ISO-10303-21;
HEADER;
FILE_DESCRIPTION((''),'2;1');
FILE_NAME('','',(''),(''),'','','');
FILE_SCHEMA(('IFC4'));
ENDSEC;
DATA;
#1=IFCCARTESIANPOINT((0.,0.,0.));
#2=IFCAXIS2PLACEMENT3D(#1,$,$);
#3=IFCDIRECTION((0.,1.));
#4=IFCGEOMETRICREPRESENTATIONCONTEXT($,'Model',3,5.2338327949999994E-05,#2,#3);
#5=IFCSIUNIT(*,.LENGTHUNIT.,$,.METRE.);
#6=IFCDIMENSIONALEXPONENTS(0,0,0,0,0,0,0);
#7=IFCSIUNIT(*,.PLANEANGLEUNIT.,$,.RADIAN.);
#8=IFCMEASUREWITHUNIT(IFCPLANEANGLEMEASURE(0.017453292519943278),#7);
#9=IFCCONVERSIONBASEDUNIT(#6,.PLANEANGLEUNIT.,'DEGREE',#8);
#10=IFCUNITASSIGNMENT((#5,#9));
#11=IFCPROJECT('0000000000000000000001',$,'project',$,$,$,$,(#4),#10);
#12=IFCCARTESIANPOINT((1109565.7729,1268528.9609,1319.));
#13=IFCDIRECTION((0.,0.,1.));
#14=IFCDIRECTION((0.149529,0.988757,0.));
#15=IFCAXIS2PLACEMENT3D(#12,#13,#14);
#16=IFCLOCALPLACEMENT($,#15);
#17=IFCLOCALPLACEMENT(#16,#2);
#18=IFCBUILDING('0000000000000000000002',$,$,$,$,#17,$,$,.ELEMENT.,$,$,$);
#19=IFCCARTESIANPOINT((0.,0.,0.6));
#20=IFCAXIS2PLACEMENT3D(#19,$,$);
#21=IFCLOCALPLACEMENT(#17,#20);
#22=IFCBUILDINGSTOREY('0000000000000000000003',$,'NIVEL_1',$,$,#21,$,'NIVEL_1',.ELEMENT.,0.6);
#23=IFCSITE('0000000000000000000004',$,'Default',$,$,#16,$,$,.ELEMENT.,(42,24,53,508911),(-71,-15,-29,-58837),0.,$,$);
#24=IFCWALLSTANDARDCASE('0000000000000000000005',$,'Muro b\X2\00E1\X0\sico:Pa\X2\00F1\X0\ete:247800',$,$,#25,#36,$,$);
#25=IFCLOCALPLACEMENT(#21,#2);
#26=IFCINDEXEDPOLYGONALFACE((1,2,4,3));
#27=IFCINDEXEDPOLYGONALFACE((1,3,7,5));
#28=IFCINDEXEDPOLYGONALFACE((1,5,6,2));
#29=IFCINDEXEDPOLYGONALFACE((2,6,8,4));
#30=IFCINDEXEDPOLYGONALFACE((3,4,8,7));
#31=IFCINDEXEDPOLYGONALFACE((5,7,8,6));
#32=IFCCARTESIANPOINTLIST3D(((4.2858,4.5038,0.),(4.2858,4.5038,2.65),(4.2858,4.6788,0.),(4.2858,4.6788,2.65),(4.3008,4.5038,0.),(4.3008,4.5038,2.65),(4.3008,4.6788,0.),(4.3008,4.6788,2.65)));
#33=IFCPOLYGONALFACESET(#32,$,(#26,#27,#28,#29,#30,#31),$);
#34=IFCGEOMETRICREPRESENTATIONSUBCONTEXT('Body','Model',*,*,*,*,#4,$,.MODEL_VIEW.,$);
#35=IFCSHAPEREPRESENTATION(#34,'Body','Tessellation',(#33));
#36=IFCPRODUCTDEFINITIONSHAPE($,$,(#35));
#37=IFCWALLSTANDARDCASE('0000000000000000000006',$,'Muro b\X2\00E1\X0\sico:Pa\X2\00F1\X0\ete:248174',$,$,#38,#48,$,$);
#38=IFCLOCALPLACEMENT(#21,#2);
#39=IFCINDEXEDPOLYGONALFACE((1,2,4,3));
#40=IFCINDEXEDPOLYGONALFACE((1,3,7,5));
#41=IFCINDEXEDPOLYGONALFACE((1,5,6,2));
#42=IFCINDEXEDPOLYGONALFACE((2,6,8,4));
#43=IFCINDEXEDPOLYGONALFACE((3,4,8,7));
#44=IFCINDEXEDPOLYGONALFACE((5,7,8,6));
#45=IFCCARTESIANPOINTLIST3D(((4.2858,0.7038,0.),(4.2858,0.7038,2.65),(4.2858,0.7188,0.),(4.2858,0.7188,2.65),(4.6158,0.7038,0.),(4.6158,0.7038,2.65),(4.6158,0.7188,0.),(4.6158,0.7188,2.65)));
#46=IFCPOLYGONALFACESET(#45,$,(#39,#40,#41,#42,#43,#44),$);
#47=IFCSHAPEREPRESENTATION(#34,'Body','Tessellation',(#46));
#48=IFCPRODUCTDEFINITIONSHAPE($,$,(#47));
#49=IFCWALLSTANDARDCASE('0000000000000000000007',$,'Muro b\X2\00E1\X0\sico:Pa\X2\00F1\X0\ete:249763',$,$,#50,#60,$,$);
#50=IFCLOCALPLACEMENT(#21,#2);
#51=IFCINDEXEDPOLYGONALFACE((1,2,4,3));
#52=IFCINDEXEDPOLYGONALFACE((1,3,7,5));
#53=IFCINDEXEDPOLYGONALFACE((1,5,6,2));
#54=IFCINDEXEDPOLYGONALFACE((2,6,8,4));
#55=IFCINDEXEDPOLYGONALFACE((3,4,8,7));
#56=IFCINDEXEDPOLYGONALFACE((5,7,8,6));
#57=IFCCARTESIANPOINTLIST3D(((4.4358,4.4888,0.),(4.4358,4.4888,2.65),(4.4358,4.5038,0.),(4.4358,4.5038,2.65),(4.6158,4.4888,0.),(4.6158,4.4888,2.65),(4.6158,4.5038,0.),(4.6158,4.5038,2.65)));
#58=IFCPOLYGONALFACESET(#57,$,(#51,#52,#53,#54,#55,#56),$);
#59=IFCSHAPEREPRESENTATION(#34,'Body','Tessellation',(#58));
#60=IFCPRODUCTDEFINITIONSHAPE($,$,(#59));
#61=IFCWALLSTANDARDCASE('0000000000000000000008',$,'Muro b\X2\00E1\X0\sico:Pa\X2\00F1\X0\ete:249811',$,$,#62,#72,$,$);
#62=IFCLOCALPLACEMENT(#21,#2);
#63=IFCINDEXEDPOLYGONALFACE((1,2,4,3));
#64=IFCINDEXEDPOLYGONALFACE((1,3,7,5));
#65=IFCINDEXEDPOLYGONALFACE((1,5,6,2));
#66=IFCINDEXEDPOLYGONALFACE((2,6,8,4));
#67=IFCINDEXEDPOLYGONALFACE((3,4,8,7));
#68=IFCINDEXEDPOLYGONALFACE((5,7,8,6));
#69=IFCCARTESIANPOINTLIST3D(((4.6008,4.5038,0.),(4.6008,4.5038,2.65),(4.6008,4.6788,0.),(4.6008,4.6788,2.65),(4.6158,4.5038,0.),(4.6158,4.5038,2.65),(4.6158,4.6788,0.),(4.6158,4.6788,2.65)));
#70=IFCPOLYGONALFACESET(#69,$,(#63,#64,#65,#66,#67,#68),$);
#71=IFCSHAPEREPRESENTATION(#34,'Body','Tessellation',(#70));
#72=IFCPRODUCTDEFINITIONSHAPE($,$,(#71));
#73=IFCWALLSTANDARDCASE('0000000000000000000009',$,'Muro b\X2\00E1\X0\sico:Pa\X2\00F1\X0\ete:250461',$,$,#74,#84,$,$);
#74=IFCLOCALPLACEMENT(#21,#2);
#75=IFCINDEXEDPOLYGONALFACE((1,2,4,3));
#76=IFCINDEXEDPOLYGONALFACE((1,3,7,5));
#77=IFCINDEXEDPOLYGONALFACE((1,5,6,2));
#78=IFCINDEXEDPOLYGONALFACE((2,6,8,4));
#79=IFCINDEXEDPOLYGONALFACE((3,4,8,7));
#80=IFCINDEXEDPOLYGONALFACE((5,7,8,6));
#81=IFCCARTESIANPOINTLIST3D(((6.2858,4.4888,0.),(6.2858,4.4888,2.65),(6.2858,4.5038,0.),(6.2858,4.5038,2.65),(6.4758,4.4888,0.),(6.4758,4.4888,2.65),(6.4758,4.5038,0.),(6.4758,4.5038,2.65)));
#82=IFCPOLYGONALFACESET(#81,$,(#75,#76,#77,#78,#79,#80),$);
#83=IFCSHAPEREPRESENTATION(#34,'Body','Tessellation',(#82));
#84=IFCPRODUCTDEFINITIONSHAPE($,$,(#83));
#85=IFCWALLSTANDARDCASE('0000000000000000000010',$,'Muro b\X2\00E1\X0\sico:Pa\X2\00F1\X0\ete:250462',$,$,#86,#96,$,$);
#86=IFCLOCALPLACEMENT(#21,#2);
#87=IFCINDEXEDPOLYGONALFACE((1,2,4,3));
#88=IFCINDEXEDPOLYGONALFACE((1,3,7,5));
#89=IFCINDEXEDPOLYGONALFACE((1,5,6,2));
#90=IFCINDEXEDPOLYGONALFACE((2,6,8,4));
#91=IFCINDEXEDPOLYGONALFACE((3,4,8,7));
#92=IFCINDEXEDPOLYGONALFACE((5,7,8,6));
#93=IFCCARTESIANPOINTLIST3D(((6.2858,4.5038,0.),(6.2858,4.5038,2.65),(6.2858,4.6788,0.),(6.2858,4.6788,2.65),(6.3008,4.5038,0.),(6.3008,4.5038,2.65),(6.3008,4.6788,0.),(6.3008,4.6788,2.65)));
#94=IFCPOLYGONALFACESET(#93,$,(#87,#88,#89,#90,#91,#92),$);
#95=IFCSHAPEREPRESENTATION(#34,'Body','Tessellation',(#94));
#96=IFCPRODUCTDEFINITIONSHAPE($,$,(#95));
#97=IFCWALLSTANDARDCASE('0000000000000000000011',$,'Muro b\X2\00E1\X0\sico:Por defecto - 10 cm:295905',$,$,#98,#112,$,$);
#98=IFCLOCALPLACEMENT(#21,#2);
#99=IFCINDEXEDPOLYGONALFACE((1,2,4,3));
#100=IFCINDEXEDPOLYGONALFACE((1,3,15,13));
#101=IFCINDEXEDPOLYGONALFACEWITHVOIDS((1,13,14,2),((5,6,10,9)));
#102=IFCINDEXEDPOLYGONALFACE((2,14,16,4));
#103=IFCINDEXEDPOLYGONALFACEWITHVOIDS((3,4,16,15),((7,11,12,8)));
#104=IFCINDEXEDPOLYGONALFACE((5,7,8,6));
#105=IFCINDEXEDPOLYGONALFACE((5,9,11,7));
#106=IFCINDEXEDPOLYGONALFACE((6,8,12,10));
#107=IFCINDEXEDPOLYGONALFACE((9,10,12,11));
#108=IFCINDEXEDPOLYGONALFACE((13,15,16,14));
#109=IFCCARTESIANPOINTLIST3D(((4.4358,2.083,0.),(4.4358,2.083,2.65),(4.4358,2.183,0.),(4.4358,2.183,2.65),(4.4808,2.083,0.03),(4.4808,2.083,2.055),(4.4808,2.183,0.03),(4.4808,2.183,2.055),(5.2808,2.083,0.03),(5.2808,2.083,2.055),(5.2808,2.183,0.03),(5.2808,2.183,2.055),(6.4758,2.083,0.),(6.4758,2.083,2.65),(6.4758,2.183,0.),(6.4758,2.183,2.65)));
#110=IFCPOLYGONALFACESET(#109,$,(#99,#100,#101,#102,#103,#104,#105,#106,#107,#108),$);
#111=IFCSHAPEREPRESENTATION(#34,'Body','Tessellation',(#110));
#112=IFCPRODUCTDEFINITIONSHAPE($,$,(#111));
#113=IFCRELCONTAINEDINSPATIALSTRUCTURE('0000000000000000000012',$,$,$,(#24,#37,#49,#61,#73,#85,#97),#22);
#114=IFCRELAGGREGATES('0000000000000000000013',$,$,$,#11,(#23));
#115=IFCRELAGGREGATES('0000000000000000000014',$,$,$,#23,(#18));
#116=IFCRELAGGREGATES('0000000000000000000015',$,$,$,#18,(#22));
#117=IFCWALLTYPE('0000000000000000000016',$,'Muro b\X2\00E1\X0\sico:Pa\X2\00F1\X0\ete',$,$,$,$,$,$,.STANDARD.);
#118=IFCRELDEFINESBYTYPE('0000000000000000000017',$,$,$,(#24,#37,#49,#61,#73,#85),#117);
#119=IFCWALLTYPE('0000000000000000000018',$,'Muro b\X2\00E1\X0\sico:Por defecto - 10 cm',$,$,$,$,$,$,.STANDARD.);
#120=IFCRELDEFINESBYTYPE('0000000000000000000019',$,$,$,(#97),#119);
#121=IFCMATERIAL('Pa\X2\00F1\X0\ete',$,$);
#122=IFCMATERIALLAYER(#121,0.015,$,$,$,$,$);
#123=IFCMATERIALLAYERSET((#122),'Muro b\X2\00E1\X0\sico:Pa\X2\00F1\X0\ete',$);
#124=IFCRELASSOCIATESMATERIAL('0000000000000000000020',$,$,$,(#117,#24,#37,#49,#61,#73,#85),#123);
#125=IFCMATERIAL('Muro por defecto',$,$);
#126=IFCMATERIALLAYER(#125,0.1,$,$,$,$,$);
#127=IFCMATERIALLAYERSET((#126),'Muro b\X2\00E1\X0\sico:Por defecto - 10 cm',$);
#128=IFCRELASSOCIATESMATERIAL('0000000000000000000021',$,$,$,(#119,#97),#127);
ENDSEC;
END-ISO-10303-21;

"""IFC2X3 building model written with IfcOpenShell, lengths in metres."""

from ifc_helpers import new_model, entity, si_unit, converted_unit, direction, frame, frame_2d, origin, place, context, subcontext, project, spatial, rectangle, extrude, material, layer, layer_set, layer_usage, type_object, element, save


model = new_model("IFC2X3")

# Units and contexts
model_context = context("Model", 3, precision=5.2338327949999994e-05, world=origin(), true_north=direction((0.0, 1.0)))
body_context = subcontext(model_context, "Body", "Model", "MODEL_VIEW")
ifc_project = project(units=[si_unit("LENGTHUNIT", "METRE"), converted_unit("PLANEANGLEUNIT", "DEGREE", entity("IfcPlaneAngleMeasure", 0.017453292519943278), si_unit("PLANEANGLEUNIT", "RADIAN"), dimensions=[0, 0, 0, 0, 0, 0, 0])], contexts=[model_context])

# Site, building, storey
site_placement = place(None, frame((1109565.7729, 1268528.9609, 1319.0), z_axis=(0.0, 0.0, 1.0), x_axis=(0.149529, 0.988757, 0.0)))
site = spatial("IfcSite", under=ifc_project, at=site_placement, Name="Default", CompositionType="ELEMENT", RefLatitude=(42, 24, 53, 508911), RefLongitude=(-71, -15, -29, -58837), RefElevation=0.0)
building_placement = place(site_placement, origin())
building = spatial("IfcBuilding", under=site, at=building_placement, CompositionType="ELEMENT")
storey_placement = place(building_placement, frame((0.0, 0.0, 0.6)))
storey = spatial("IfcBuildingStorey", under=building, at=storey_placement, Name="NIVEL_1", LongName="NIVEL_1", CompositionType="ELEMENT", Elevation=0.6)

# Shared definitions
ifc_material_1 = material(Name="Pañete")

# Walls
ifc_layer_1 = layer(ifc_material_1, 0.015)
ifc_layer_set_1 = layer_set([ifc_layer_1], Name="Muro básico:Pañete")
ifc_layer_usage_1 = layer_usage(ifc_layer_set_1, "AXIS2", "NEGATIVE", 0.0075)
wall_type_1 = type_object("IfcWallType", Name="Muro básico:Pañete", PredefinedType="STANDARD", material=ifc_layer_set_1)
wall_1_placement = place(storey_placement, frame((4.2933, 4.5038, 0.0), z_axis=(0.0, 0.0, 1.0), x_axis=(0.0, 1.0, 0.0)))
element("IfcWallStandardCase", 1, at=wall_1_placement, inside=storey, type_object=wall_type_1, material=ifc_layer_usage_1, Name="Muro básico:Pañete:247800", context=body_context, shape_type="SweptSolid", body=[
    extrude(rectangle(XDim=0.175, YDim=0.015, at=frame_2d((0.0875, 0.0), x_axis=(-1.0, 0.0))), origin(), (0.0, 0.0, 1.0), 2.65),
])
ifc_layer_usage_2 = layer_usage(ifc_layer_set_1, "AXIS2", "NEGATIVE", 0.0075)
wall_2_placement = place(storey_placement, frame((4.2858, 0.7113, 0.0)))
element("IfcWallStandardCase", 2, at=wall_2_placement, inside=storey, type_object=wall_type_1, material=ifc_layer_usage_2, Name="Muro básico:Pañete:248174", context=body_context, shape_type="SweptSolid", body=[
    extrude(rectangle(XDim=0.33, YDim=0.015, at=frame_2d((0.165, 0.0), x_axis=(-1.0, 0.0))), origin(), (0.0, 0.0, 1.0), 2.65),
])
ifc_layer_usage_3 = layer_usage(ifc_layer_set_1, "AXIS2", "POSITIVE", -0.0075)
wall_3_placement = place(storey_placement, frame((4.4358, 4.4963, 0.0)))
element("IfcWallStandardCase", 3, at=wall_3_placement, inside=storey, type_object=wall_type_1, material=ifc_layer_usage_3, Name="Muro básico:Pañete:249763", context=body_context, shape_type="SweptSolid", body=[
    extrude(rectangle(XDim=0.18, YDim=0.015, at=frame_2d((0.09, 0.0), x_axis=(-1.0, 0.0))), origin(), (0.0, 0.0, 1.0), 2.65),
])
ifc_layer_usage_4 = layer_usage(ifc_layer_set_1, "AXIS2", "POSITIVE", -0.0075)
wall_4_placement = place(storey_placement, frame((4.6083, 4.5038, 0.0), z_axis=(0.0, 0.0, 1.0), x_axis=(0.0, 1.0, 0.0)))
element("IfcWallStandardCase", 4, at=wall_4_placement, inside=storey, type_object=wall_type_1, material=ifc_layer_usage_4, Name="Muro básico:Pañete:249811", context=body_context, shape_type="SweptSolid", body=[
    extrude(rectangle(XDim=0.175, YDim=0.015, at=frame_2d((0.0875, 0.0), x_axis=(-1.0, 0.0))), origin(), (0.0, 0.0, 1.0), 2.65),
])
ifc_layer_usage_5 = layer_usage(ifc_layer_set_1, "AXIS2", "NEGATIVE", 0.0075)
wall_5_placement = place(storey_placement, frame((6.4758, 4.4963, 0.0), z_axis=(0.0, 0.0, 1.0), x_axis=(-1.0, 0.0, 0.0)))
element("IfcWallStandardCase", 5, at=wall_5_placement, inside=storey, type_object=wall_type_1, material=ifc_layer_usage_5, Name="Muro básico:Pañete:250461", context=body_context, shape_type="SweptSolid", body=[
    extrude(rectangle(XDim=0.19, YDim=0.015, at=frame_2d((0.095, 0.0), x_axis=(-1.0, 0.0))), origin(), (0.0, 0.0, 1.0), 2.65),
])
ifc_layer_usage_6 = layer_usage(ifc_layer_set_1, "AXIS2", "NEGATIVE", 0.0075)
wall_6_placement = place(storey_placement, frame((6.2933, 4.5038, 0.0), z_axis=(0.0, 0.0, 1.0), x_axis=(0.0, 1.0, 0.0)))
element("IfcWallStandardCase", 6, at=wall_6_placement, inside=storey, type_object=wall_type_1, material=ifc_layer_usage_6, Name="Muro básico:Pañete:250462", context=body_context, shape_type="SweptSolid", body=[
    extrude(rectangle(XDim=0.175, YDim=0.015, at=frame_2d((0.0875, 0.0), x_axis=(-1.0, 0.0))), origin(), (0.0, 0.0, 1.0), 2.65),
])

# Wall, opening
ifc_material_2 = material(Name="Muro por defecto")
ifc_layer_2 = layer(ifc_material_2, 0.1)
ifc_layer_set_2 = layer_set([ifc_layer_2], Name="Muro básico:Por defecto - 10 cm")
ifc_layer_usage_7 = layer_usage(ifc_layer_set_2, "AXIS2", "NEGATIVE", 0.05)
wall_type_2 = type_object("IfcWallType", Name="Muro básico:Por defecto - 10 cm", PredefinedType="STANDARD", material=ifc_layer_set_2)
wall_7_placement = place(storey_placement, frame((6.4758, 2.133, 0.0), z_axis=(0.0, 0.0, 1.0), x_axis=(-1.0, 0.0, 0.0)))
wall_7 = element("IfcWallStandardCase", 7, at=wall_7_placement, inside=storey, type_object=wall_type_2, material=ifc_layer_usage_7, Name="Muro básico:Por defecto - 10 cm:295905", context=body_context, shape_type="SweptSolid", body=[
    extrude(rectangle(XDim=2.04, YDim=0.1, at=frame_2d((1.02, 0.0), x_axis=(-1.0, 0.0))), origin(), (0.0, 0.0, 1.0), 2.65),
])
opening_1_placement = place(wall_7_placement, frame((1.995, 0.05, 0.03)))
element("IfcOpeningElement", 8, at=opening_1_placement, cuts=wall_7, ObjectType="Opening", context=body_context, shape_type="SweptSolid", body=[
    extrude(rectangle(XDim=2.025, YDim=0.8, at=frame_2d((1.0125, 0.4), x_axis=(1.0, 0.0))), frame((0.0, 0.0, 0.0), z_axis=(0.0, -1.0, 0.0), x_axis=(0.0, 0.0, 1.0)), (0.0, 0.0, 1.0), 0.1),
])

save(model, "model.ifc")
